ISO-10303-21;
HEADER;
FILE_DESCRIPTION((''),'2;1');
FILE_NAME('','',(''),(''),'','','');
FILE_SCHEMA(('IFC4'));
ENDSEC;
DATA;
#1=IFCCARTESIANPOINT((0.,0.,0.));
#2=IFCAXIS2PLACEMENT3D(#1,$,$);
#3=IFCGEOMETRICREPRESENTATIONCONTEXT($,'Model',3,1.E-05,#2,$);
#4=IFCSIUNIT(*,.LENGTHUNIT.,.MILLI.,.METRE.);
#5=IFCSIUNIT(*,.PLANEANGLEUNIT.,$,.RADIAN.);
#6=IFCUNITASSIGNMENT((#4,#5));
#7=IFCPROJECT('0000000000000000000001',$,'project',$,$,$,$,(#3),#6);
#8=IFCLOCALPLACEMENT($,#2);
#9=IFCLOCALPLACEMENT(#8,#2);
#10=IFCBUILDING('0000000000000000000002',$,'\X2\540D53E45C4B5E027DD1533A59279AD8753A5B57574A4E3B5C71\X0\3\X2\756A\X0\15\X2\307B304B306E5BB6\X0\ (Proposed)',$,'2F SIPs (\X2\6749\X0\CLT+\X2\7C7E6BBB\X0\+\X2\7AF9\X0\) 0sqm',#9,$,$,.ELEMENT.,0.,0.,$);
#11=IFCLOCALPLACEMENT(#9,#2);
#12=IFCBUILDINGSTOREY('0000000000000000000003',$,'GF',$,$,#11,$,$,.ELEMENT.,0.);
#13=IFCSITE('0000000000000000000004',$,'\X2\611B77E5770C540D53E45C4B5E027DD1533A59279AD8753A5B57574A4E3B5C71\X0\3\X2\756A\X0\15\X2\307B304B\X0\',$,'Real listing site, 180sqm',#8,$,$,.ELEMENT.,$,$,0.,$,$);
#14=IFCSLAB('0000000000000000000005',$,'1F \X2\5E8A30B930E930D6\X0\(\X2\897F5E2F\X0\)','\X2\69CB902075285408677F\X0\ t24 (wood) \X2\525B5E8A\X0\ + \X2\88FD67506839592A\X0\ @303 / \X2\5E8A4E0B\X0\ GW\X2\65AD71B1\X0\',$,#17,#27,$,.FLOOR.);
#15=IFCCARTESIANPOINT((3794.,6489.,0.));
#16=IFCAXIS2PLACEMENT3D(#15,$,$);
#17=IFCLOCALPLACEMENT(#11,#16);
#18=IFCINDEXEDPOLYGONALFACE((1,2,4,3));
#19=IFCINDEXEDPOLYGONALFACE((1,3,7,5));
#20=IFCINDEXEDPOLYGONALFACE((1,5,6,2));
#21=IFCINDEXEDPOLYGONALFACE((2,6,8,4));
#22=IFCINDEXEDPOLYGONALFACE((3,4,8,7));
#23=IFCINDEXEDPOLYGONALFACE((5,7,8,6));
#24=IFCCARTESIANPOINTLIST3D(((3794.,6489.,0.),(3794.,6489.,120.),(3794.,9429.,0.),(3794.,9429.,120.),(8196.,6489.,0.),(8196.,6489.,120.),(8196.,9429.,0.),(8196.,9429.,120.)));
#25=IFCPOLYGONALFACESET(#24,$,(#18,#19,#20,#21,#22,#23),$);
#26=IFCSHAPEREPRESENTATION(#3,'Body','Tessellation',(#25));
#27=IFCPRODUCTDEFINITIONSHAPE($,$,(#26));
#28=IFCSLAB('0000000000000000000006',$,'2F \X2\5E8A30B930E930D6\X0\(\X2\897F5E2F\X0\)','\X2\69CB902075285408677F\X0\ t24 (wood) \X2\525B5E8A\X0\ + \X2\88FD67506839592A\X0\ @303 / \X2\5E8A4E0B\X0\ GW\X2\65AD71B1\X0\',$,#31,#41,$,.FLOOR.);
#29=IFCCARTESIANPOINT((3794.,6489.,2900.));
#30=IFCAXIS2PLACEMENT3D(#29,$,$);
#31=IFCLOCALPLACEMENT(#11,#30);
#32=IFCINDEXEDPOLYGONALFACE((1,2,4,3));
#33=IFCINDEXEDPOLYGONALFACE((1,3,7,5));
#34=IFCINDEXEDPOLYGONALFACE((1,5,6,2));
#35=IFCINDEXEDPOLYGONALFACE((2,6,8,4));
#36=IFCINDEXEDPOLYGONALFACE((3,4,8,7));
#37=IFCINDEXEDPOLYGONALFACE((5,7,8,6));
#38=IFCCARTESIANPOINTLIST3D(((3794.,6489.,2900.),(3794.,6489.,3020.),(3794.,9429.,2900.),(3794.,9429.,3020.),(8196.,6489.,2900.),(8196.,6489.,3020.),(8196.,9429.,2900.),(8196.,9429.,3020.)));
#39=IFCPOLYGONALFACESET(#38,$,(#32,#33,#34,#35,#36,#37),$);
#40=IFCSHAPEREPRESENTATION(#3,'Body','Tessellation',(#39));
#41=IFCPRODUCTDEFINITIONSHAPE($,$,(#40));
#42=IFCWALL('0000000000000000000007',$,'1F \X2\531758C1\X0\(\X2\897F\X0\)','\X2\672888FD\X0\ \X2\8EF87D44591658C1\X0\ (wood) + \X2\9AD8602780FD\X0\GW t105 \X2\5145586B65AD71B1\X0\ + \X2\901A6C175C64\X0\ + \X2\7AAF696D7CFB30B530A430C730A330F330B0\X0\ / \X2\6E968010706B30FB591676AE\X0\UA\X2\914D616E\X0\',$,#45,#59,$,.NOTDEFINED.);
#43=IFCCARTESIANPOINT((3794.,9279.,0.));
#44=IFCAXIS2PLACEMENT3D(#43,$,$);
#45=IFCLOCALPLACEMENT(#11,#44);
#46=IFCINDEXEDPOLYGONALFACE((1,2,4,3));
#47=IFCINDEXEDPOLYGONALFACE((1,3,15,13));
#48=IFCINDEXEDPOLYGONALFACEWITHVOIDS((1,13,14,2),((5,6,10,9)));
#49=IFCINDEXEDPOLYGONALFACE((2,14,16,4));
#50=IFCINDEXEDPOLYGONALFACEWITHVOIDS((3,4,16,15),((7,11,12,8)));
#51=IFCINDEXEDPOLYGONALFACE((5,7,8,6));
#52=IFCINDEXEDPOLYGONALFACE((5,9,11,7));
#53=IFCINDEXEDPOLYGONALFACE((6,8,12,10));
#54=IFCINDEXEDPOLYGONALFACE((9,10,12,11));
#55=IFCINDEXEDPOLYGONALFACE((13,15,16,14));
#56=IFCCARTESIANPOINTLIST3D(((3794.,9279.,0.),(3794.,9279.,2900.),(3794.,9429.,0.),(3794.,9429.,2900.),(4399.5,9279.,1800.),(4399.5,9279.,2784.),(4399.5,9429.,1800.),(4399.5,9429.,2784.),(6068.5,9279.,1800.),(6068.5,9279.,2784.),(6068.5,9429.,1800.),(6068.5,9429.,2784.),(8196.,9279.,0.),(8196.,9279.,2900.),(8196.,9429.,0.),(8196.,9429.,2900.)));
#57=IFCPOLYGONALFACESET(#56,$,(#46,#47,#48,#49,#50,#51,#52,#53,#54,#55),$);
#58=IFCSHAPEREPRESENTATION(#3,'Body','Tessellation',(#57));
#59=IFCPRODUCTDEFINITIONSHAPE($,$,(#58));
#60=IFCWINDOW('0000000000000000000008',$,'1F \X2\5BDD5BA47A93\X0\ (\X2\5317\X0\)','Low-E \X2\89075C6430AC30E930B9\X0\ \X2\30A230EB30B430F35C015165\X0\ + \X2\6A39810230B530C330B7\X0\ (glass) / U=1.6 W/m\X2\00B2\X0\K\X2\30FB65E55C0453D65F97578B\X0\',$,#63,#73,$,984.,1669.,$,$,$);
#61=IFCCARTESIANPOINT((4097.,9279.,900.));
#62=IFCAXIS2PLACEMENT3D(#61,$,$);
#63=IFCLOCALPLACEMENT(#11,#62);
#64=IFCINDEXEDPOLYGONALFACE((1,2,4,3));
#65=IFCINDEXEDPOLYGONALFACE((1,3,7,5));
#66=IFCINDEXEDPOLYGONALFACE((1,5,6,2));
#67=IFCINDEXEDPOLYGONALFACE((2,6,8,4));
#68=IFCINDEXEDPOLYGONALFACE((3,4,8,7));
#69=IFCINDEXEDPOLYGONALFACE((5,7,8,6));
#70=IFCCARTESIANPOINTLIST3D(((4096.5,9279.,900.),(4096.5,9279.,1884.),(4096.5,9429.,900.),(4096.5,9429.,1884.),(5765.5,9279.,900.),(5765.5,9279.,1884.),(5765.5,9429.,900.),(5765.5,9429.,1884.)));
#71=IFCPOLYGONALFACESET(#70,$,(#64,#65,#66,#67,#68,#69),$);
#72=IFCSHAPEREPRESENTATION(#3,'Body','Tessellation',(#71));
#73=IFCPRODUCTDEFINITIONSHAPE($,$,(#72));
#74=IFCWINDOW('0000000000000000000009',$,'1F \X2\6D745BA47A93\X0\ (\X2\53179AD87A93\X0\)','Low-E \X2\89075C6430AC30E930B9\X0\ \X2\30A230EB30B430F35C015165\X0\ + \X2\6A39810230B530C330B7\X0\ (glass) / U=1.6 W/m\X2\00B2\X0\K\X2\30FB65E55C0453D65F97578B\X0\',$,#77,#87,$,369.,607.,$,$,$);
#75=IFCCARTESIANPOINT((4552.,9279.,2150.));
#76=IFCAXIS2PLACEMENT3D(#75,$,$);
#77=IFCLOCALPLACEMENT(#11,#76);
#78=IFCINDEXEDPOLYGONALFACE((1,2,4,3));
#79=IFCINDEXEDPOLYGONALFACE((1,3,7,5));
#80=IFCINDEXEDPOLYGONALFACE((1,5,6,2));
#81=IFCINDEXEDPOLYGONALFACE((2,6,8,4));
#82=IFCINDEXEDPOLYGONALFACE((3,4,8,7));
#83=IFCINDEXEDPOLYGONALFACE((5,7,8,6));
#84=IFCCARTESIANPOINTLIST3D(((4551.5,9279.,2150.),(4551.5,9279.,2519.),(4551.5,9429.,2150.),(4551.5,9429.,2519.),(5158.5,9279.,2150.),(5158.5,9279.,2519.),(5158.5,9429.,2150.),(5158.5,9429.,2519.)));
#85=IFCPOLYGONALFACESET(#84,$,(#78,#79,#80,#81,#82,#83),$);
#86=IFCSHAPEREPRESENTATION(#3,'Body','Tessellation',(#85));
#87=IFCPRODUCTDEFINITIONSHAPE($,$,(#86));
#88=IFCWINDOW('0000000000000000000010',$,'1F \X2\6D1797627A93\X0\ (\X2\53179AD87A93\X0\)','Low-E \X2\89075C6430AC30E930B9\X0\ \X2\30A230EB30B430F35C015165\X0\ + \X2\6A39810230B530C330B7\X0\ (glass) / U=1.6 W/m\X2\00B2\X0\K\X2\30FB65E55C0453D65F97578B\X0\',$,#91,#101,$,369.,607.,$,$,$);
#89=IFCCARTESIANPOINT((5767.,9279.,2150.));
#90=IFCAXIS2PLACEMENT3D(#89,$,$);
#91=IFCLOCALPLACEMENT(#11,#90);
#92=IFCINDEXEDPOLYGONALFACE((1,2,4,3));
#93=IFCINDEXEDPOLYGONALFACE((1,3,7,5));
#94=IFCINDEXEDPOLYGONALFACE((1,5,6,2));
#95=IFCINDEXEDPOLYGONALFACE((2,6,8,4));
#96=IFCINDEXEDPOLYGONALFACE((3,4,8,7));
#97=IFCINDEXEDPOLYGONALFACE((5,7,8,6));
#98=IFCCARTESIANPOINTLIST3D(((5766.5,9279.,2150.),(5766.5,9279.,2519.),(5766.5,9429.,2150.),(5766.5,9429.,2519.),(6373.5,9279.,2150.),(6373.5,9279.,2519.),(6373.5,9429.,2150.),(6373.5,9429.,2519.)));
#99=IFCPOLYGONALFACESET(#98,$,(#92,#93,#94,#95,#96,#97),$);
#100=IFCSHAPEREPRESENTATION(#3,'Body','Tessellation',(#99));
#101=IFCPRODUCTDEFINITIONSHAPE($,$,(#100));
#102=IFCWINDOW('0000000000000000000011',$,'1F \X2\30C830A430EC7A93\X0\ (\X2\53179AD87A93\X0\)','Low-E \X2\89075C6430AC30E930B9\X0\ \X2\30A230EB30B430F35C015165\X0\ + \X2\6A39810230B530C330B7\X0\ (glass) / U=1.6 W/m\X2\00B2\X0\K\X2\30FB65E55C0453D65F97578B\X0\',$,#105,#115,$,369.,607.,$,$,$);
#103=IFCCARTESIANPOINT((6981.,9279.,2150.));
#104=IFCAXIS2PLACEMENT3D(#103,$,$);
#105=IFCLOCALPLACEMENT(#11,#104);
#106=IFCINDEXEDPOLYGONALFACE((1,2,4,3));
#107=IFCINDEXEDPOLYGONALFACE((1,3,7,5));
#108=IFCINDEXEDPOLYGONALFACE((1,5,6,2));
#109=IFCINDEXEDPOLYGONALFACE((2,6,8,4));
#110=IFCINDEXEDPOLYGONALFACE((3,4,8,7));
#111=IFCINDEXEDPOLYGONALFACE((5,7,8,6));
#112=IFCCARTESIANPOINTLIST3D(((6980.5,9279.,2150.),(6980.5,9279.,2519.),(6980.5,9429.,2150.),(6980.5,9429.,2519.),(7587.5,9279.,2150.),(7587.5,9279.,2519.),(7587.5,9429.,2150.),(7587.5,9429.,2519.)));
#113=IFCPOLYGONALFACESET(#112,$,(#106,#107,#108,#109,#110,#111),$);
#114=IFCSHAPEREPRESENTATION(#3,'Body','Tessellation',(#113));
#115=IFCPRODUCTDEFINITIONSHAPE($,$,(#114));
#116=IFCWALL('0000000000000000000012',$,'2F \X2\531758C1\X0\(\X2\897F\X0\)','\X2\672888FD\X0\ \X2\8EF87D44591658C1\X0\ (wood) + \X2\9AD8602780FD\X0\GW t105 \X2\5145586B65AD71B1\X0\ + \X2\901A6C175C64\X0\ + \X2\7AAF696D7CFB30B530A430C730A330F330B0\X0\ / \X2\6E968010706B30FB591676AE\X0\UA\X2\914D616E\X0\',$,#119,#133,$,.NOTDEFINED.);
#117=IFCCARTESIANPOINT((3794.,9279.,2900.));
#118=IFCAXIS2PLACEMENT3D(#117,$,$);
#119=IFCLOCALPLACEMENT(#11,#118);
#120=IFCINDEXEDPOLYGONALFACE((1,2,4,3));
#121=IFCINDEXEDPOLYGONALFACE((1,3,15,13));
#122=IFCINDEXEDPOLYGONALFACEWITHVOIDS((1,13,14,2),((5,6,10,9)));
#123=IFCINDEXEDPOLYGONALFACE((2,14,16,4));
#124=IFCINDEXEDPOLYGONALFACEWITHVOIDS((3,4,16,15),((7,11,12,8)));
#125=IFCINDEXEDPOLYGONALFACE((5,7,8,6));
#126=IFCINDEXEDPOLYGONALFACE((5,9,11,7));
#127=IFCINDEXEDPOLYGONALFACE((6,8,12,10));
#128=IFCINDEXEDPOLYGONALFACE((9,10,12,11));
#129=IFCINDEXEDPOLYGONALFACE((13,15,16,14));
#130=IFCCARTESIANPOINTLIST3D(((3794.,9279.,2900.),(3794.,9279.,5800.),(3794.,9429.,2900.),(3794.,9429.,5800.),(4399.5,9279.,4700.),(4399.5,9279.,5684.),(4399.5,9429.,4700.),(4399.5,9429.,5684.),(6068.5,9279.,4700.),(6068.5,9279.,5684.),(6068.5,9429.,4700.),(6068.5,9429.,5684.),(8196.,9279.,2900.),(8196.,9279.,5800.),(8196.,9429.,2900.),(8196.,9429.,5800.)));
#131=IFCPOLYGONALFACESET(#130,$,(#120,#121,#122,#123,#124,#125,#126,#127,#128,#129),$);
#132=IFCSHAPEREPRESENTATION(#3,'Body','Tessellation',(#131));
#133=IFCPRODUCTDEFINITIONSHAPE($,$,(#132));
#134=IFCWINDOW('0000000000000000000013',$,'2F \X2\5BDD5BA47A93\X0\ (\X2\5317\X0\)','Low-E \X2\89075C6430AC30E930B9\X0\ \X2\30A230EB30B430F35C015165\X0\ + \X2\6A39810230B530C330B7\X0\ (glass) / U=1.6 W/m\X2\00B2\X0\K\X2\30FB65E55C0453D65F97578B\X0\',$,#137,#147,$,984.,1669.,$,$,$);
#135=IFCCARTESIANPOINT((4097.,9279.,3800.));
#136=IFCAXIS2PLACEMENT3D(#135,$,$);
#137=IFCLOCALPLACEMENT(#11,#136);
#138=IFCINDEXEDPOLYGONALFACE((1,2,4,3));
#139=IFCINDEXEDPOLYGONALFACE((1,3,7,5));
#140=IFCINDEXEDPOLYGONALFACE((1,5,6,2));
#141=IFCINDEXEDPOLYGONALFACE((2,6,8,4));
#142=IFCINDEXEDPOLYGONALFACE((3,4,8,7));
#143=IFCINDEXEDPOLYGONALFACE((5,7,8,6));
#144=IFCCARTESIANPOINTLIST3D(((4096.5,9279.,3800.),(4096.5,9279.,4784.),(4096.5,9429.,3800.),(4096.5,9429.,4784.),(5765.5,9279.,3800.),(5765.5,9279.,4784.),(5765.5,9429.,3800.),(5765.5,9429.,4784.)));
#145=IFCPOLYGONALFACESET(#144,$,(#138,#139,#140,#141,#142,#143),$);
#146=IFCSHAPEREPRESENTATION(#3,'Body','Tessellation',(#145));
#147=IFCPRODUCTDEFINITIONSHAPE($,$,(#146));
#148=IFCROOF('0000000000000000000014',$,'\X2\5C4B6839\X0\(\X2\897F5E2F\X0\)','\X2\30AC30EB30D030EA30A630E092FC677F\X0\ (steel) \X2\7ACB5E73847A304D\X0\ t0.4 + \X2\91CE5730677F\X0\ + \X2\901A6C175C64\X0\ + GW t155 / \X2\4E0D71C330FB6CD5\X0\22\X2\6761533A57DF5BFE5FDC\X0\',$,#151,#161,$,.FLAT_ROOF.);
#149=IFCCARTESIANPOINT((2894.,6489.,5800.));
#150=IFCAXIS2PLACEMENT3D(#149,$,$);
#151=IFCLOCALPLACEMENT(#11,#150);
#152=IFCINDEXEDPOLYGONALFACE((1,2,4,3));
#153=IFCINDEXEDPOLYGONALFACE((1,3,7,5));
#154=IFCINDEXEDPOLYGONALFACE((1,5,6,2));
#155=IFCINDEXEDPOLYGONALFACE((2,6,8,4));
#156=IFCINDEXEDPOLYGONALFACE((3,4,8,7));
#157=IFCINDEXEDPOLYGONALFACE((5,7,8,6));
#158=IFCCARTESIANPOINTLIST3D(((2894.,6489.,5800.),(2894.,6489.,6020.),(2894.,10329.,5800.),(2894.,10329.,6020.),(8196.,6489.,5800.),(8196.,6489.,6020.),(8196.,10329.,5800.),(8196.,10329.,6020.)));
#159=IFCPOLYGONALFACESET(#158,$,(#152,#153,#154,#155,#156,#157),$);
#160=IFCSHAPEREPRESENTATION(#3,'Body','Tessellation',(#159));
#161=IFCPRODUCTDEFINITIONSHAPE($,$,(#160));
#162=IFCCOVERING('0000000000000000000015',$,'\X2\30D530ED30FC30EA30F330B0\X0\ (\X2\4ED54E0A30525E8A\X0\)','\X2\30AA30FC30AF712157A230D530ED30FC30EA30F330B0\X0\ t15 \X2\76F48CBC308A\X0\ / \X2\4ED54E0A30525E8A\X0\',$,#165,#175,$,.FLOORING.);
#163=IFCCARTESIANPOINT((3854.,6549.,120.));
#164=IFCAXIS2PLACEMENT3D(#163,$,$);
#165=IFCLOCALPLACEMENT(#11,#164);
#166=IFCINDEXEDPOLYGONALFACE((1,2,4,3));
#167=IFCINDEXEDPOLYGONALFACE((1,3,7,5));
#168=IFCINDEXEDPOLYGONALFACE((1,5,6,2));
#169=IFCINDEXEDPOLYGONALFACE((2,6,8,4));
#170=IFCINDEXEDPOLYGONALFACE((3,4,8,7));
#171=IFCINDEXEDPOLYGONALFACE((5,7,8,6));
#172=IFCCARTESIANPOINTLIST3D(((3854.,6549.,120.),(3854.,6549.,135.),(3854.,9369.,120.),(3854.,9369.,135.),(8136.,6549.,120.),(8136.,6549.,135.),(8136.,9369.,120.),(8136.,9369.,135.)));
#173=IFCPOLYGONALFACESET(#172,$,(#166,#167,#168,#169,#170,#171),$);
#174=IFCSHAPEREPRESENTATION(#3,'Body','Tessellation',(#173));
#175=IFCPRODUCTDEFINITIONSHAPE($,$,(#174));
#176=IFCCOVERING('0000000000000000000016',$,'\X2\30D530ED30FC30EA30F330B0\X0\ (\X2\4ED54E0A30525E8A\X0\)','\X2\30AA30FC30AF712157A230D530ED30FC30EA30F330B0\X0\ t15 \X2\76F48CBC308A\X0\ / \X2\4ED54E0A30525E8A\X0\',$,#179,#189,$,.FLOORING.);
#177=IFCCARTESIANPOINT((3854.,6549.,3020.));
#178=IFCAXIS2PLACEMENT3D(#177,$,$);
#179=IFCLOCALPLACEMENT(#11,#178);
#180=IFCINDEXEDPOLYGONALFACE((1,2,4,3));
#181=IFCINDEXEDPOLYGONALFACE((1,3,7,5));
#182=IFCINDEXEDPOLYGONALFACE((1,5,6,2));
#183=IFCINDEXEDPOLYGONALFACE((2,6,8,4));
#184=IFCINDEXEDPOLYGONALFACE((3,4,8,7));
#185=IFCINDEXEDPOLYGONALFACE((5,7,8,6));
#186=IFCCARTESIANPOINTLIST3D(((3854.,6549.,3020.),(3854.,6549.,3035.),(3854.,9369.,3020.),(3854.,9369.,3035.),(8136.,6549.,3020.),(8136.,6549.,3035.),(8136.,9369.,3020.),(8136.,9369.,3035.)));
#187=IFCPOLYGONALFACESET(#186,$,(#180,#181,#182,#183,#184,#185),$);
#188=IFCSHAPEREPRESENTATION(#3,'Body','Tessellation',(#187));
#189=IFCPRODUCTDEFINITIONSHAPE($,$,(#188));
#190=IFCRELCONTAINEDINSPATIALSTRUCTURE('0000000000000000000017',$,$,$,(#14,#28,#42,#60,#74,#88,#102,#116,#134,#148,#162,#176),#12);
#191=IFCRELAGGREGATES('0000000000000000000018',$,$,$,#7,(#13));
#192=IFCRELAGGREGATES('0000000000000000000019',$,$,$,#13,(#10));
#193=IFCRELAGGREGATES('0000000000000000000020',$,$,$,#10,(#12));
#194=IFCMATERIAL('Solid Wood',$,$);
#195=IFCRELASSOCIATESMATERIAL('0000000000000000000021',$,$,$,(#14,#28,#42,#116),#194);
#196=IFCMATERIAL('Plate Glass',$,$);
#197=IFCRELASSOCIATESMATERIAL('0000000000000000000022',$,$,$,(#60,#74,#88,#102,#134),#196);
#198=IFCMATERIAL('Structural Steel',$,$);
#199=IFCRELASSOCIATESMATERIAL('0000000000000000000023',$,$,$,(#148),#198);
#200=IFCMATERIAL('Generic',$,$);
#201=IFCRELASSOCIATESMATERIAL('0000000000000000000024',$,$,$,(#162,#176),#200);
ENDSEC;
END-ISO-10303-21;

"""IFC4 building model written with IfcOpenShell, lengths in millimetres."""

from ifc_helpers import new_model, si_unit, frame, frame_2d, origin, place, context, project, spatial, rectangle, extrude, material, element, fill, save


model = new_model("IFC4")

# Units and contexts
model_context = context("Model", 3, precision=1e-05, world=origin())
ifc_project = project(units=[si_unit("LENGTHUNIT", "METRE", prefix="MILLI"), si_unit("PLANEANGLEUNIT", "RADIAN")], contexts=[model_context])

# Site, building, storey
site_placement = place(None, origin())
site = spatial("IfcSite", under=ifc_project, at=site_placement, Name="愛知県名古屋市緑区大高町字坊主山3番15ほか", ObjectType="Real listing site, 180sqm", CompositionType="ELEMENT", RefElevation=0.0)
building_placement = place(site_placement, origin())
building = spatial("IfcBuilding", under=site, at=building_placement, Name="名古屋市緑区大高町字坊主山3番15ほかの家 (Proposed)", ObjectType="2F SIPs (杉CLT+籾殻+竹) 0sqm", CompositionType="ELEMENT", ElevationOfRefHeight=0.0, ElevationOfTerrain=0.0)
storey_placement = place(building_placement, origin())
storey = spatial("IfcBuildingStorey", under=building, at=storey_placement, Name="GF", CompositionType="ELEMENT", Elevation=0.0)

# Slabs
ifc_material_1 = material(Name="Solid Wood")
slab_1_placement = place(storey_placement, frame((3794.0, 6489.0, 0.0)))
element("IfcSlab", 1, at=slab_1_placement, inside=storey, material=ifc_material_1, Name="1F 床スラブ(西帯)", Description="構造用合板 t24 (wood) 剛床 + 製材根太 @303 / 床下 GW断熱", PredefinedType="FLOOR", context=model_context, shape_type="SweptSolid", body=[
    extrude(rectangle(XDim=4402.0, YDim=2940.0, at=frame_2d((2201.0, 1470.0))), frame((3794.0, 6489.0, 0.0)), (0.0, 0.0, 1.0), 120.0),
])
slab_2_placement = place(storey_placement, frame((3794.0, 6489.0, 2900.0)))
element("IfcSlab", 2, at=slab_2_placement, inside=storey, material=ifc_material_1, Name="2F 床スラブ(西帯)", Description="構造用合板 t24 (wood) 剛床 + 製材根太 @303 / 床下 GW断熱", PredefinedType="FLOOR", context=model_context, shape_type="SweptSolid", body=[
    extrude(rectangle(XDim=4402.0, YDim=2940.0, at=frame_2d((2201.0, 1470.0))), frame((3794.0, 6489.0, 2900.0)), (0.0, 0.0, 1.0), 120.0),
])

# Wall, openings, windows
wall_1_placement = place(storey_placement, frame((3794.0, 9279.0, 0.0)))
wall_1 = element("IfcWall", 3, at=wall_1_placement, inside=storey, material=ifc_material_1, Name="1F 北壁(西)", Description="木製 軸組外壁 (wood) + 高性能GW t105 充填断熱 + 通気層 + 窯業系サイディング / 準耐火・外皮UA配慮", PredefinedType="NOTDEFINED", context=model_context, shape_type="SweptSolid", body=[
    extrude(rectangle(XDim=4402.0, YDim=150.0, at=frame_2d((2201.0, 75.0))), frame((3794.0, 9279.0, 0.0)), (0.0, 0.0, 1.0), 2900.0),
])
opening_1_placement = place(storey_placement, frame((4097.0, 9279.0, 900.0)))
opening_1 = element("IfcOpeningElement", 4, at=opening_1_placement, cuts=wall_1, PredefinedType="NOTDEFINED", context=model_context, shape_type="SweptSolid", body=[
    extrude(rectangle(XDim=1669.0, YDim=150.0, at=frame_2d((834.0, 75.0))), frame((4097.0, 9279.0, 900.0)), (0.0, 0.0, 1.0), 984.0),
])
opening_2_placement = place(storey_placement, frame((4552.0, 9279.0, 2150.0)))
opening_2 = element("IfcOpeningElement", 5, at=opening_2_placement, cuts=wall_1, PredefinedType="NOTDEFINED", context=model_context, shape_type="SweptSolid", body=[
    extrude(rectangle(XDim=607.0, YDim=150.0, at=frame_2d((303.0, 75.0))), frame((4552.0, 9279.0, 2150.0)), (0.0, 0.0, 1.0), 369.0),
])
opening_3_placement = place(storey_placement, frame((5767.0, 9279.0, 2150.0)))
opening_3 = element("IfcOpeningElement", 6, at=opening_3_placement, cuts=wall_1, PredefinedType="NOTDEFINED", context=model_context, shape_type="SweptSolid", body=[
    extrude(rectangle(XDim=607.0, YDim=150.0, at=frame_2d((303.0, 75.0))), frame((5767.0, 9279.0, 2150.0)), (0.0, 0.0, 1.0), 369.0),
])
opening_4_placement = place(storey_placement, frame((6981.0, 9279.0, 2150.0)))
opening_4 = element("IfcOpeningElement", 7, at=opening_4_placement, cuts=wall_1, PredefinedType="NOTDEFINED", context=model_context, shape_type="SweptSolid", body=[
    extrude(rectangle(XDim=607.0, YDim=150.0, at=frame_2d((303.0, 75.0))), frame((6981.0, 9279.0, 2150.0)), (0.0, 0.0, 1.0), 369.0),
])
ifc_material_2 = material(Name="Plate Glass")
window_1_placement = place(storey_placement, frame((4097.0, 9279.0, 900.0)))
window_1 = element("IfcWindow", 8, at=window_1_placement, inside=storey, material=ifc_material_2, Name="1F 寝室窓 (北)", Description="Low-E 複層ガラス アルゴン封入 + 樹脂サッシ (glass) / U=1.6 W/m²K・日射取得型", OverallHeight=984.0, OverallWidth=1669.0, context=model_context, shape_type="SweptSolid", body=[
    extrude(rectangle(XDim=1669.0, YDim=150.0, at=frame_2d((834.0, 75.0))), frame((4097.0, 9279.0, 900.0)), (0.0, 0.0, 1.0), 984.0),
])
fill(opening_1, window_1)
window_2_placement = place(storey_placement, frame((4552.0, 9279.0, 2150.0)))
window_2 = element("IfcWindow", 9, at=window_2_placement, inside=storey, material=ifc_material_2, Name="1F 浴室窓 (北高窓)", Description="Low-E 複層ガラス アルゴン封入 + 樹脂サッシ (glass) / U=1.6 W/m²K・日射取得型", OverallHeight=369.0, OverallWidth=607.0, context=model_context, shape_type="SweptSolid", body=[
    extrude(rectangle(XDim=607.0, YDim=150.0, at=frame_2d((303.0, 75.0))), frame((4552.0, 9279.0, 2150.0)), (0.0, 0.0, 1.0), 369.0),
])
fill(opening_2, window_2)
window_3_placement = place(storey_placement, frame((5767.0, 9279.0, 2150.0)))
window_3 = element("IfcWindow", 10, at=window_3_placement, inside=storey, material=ifc_material_2, Name="1F 洗面窓 (北高窓)", Description="Low-E 複層ガラス アルゴン封入 + 樹脂サッシ (glass) / U=1.6 W/m²K・日射取得型", OverallHeight=369.0, OverallWidth=607.0, context=model_context, shape_type="SweptSolid", body=[
    extrude(rectangle(XDim=607.0, YDim=150.0, at=frame_2d((303.0, 75.0))), frame((5767.0, 9279.0, 2150.0)), (0.0, 0.0, 1.0), 369.0),
])
fill(opening_3, window_3)
window_4_placement = place(storey_placement, frame((6981.0, 9279.0, 2150.0)))
window_4 = element("IfcWindow", 11, at=window_4_placement, inside=storey, material=ifc_material_2, Name="1F トイレ窓 (北高窓)", Description="Low-E 複層ガラス アルゴン封入 + 樹脂サッシ (glass) / U=1.6 W/m²K・日射取得型", OverallHeight=369.0, OverallWidth=607.0, context=model_context, shape_type="SweptSolid", body=[
    extrude(rectangle(XDim=607.0, YDim=150.0, at=frame_2d((303.0, 75.0))), frame((6981.0, 9279.0, 2150.0)), (0.0, 0.0, 1.0), 369.0),
])
fill(opening_4, window_4)

# Wall, opening, window
wall_2_placement = place(storey_placement, frame((3794.0, 9279.0, 2900.0)))
wall_2 = element("IfcWall", 12, at=wall_2_placement, inside=storey, material=ifc_material_1, Name="2F 北壁(西)", Description="木製 軸組外壁 (wood) + 高性能GW t105 充填断熱 + 通気層 + 窯業系サイディング / 準耐火・外皮UA配慮", PredefinedType="NOTDEFINED", context=model_context, shape_type="SweptSolid", body=[
    extrude(rectangle(XDim=4402.0, YDim=150.0, at=frame_2d((2201.0, 75.0))), frame((3794.0, 9279.0, 2900.0)), (0.0, 0.0, 1.0), 2900.0),
])
opening_5_placement = place(storey_placement, frame((4097.0, 9279.0, 3800.0)))
opening_5 = element("IfcOpeningElement", 13, at=opening_5_placement, cuts=wall_2, PredefinedType="NOTDEFINED", context=model_context, shape_type="SweptSolid", body=[
    extrude(rectangle(XDim=1669.0, YDim=150.0, at=frame_2d((834.0, 75.0))), frame((4097.0, 9279.0, 3800.0)), (0.0, 0.0, 1.0), 984.0),
])
window_5_placement = place(storey_placement, frame((4097.0, 9279.0, 3800.0)))
window_5 = element("IfcWindow", 14, at=window_5_placement, inside=storey, material=ifc_material_2, Name="2F 寝室窓 (北)", Description="Low-E 複層ガラス アルゴン封入 + 樹脂サッシ (glass) / U=1.6 W/m²K・日射取得型", OverallHeight=984.0, OverallWidth=1669.0, context=model_context, shape_type="SweptSolid", body=[
    extrude(rectangle(XDim=1669.0, YDim=150.0, at=frame_2d((834.0, 75.0))), frame((4097.0, 9279.0, 3800.0)), (0.0, 0.0, 1.0), 984.0),
])
fill(opening_5, window_5)

# Roof
ifc_material_3 = material(Name="Structural Steel")
for number, where, name in (
    (15, (2894.0, 6489.0, 5800.0), "屋根(西帯)"),
):
    element("IfcRoof", number, at=place(storey_placement, frame(where)), inside=storey, material=ifc_material_3, Name=name, Description="ガルバリウム鋼板 (steel) 立平葺き t0.4 + 野地板 + 通気層 + GW t155 / 不燃・法22条区域対応", PredefinedType="FLAT_ROOF", context=model_context, shape_type="SweptSolid", body=[
        extrude(rectangle(XDim=5302.0, YDim=3840.0, at=frame_2d((2651.0, 1920.0))), frame((2894.0, 6489.0, 5800.0)), (0.0, 0.0, 1.0), 220.0),
    ])

# Coverings
ifc_material_4 = material(Name="Generic")
covering_1_placement = place(storey_placement, frame((3854.0, 6549.0, 120.0)))
element("IfcCovering", 16, at=covering_1_placement, inside=storey, material=ifc_material_4, Name="フローリング (仕上げ床)", Description="オーク無垢フローリング t15 直貼り / 仕上げ床", PredefinedType="FLOORING", context=model_context, shape_type="SweptSolid", body=[
    extrude(rectangle(XDim=4282.0, YDim=2820.0, at=frame_2d((2141.0, 1410.0))), frame((3854.0, 6549.0, 120.0)), (0.0, 0.0, 1.0), 15.0),
])
covering_2_placement = place(storey_placement, frame((3854.0, 6549.0, 3020.0)))
element("IfcCovering", 17, at=covering_2_placement, inside=storey, material=ifc_material_4, Name="フローリング (仕上げ床)", Description="オーク無垢フローリング t15 直貼り / 仕上げ床", PredefinedType="FLOORING", context=model_context, shape_type="SweptSolid", body=[
    extrude(rectangle(XDim=4282.0, YDim=2820.0, at=frame_2d((2141.0, 1410.0))), frame((3854.0, 6549.0, 3020.0)), (0.0, 0.0, 1.0), 15.0),
])

save(model, "model.ifc")
